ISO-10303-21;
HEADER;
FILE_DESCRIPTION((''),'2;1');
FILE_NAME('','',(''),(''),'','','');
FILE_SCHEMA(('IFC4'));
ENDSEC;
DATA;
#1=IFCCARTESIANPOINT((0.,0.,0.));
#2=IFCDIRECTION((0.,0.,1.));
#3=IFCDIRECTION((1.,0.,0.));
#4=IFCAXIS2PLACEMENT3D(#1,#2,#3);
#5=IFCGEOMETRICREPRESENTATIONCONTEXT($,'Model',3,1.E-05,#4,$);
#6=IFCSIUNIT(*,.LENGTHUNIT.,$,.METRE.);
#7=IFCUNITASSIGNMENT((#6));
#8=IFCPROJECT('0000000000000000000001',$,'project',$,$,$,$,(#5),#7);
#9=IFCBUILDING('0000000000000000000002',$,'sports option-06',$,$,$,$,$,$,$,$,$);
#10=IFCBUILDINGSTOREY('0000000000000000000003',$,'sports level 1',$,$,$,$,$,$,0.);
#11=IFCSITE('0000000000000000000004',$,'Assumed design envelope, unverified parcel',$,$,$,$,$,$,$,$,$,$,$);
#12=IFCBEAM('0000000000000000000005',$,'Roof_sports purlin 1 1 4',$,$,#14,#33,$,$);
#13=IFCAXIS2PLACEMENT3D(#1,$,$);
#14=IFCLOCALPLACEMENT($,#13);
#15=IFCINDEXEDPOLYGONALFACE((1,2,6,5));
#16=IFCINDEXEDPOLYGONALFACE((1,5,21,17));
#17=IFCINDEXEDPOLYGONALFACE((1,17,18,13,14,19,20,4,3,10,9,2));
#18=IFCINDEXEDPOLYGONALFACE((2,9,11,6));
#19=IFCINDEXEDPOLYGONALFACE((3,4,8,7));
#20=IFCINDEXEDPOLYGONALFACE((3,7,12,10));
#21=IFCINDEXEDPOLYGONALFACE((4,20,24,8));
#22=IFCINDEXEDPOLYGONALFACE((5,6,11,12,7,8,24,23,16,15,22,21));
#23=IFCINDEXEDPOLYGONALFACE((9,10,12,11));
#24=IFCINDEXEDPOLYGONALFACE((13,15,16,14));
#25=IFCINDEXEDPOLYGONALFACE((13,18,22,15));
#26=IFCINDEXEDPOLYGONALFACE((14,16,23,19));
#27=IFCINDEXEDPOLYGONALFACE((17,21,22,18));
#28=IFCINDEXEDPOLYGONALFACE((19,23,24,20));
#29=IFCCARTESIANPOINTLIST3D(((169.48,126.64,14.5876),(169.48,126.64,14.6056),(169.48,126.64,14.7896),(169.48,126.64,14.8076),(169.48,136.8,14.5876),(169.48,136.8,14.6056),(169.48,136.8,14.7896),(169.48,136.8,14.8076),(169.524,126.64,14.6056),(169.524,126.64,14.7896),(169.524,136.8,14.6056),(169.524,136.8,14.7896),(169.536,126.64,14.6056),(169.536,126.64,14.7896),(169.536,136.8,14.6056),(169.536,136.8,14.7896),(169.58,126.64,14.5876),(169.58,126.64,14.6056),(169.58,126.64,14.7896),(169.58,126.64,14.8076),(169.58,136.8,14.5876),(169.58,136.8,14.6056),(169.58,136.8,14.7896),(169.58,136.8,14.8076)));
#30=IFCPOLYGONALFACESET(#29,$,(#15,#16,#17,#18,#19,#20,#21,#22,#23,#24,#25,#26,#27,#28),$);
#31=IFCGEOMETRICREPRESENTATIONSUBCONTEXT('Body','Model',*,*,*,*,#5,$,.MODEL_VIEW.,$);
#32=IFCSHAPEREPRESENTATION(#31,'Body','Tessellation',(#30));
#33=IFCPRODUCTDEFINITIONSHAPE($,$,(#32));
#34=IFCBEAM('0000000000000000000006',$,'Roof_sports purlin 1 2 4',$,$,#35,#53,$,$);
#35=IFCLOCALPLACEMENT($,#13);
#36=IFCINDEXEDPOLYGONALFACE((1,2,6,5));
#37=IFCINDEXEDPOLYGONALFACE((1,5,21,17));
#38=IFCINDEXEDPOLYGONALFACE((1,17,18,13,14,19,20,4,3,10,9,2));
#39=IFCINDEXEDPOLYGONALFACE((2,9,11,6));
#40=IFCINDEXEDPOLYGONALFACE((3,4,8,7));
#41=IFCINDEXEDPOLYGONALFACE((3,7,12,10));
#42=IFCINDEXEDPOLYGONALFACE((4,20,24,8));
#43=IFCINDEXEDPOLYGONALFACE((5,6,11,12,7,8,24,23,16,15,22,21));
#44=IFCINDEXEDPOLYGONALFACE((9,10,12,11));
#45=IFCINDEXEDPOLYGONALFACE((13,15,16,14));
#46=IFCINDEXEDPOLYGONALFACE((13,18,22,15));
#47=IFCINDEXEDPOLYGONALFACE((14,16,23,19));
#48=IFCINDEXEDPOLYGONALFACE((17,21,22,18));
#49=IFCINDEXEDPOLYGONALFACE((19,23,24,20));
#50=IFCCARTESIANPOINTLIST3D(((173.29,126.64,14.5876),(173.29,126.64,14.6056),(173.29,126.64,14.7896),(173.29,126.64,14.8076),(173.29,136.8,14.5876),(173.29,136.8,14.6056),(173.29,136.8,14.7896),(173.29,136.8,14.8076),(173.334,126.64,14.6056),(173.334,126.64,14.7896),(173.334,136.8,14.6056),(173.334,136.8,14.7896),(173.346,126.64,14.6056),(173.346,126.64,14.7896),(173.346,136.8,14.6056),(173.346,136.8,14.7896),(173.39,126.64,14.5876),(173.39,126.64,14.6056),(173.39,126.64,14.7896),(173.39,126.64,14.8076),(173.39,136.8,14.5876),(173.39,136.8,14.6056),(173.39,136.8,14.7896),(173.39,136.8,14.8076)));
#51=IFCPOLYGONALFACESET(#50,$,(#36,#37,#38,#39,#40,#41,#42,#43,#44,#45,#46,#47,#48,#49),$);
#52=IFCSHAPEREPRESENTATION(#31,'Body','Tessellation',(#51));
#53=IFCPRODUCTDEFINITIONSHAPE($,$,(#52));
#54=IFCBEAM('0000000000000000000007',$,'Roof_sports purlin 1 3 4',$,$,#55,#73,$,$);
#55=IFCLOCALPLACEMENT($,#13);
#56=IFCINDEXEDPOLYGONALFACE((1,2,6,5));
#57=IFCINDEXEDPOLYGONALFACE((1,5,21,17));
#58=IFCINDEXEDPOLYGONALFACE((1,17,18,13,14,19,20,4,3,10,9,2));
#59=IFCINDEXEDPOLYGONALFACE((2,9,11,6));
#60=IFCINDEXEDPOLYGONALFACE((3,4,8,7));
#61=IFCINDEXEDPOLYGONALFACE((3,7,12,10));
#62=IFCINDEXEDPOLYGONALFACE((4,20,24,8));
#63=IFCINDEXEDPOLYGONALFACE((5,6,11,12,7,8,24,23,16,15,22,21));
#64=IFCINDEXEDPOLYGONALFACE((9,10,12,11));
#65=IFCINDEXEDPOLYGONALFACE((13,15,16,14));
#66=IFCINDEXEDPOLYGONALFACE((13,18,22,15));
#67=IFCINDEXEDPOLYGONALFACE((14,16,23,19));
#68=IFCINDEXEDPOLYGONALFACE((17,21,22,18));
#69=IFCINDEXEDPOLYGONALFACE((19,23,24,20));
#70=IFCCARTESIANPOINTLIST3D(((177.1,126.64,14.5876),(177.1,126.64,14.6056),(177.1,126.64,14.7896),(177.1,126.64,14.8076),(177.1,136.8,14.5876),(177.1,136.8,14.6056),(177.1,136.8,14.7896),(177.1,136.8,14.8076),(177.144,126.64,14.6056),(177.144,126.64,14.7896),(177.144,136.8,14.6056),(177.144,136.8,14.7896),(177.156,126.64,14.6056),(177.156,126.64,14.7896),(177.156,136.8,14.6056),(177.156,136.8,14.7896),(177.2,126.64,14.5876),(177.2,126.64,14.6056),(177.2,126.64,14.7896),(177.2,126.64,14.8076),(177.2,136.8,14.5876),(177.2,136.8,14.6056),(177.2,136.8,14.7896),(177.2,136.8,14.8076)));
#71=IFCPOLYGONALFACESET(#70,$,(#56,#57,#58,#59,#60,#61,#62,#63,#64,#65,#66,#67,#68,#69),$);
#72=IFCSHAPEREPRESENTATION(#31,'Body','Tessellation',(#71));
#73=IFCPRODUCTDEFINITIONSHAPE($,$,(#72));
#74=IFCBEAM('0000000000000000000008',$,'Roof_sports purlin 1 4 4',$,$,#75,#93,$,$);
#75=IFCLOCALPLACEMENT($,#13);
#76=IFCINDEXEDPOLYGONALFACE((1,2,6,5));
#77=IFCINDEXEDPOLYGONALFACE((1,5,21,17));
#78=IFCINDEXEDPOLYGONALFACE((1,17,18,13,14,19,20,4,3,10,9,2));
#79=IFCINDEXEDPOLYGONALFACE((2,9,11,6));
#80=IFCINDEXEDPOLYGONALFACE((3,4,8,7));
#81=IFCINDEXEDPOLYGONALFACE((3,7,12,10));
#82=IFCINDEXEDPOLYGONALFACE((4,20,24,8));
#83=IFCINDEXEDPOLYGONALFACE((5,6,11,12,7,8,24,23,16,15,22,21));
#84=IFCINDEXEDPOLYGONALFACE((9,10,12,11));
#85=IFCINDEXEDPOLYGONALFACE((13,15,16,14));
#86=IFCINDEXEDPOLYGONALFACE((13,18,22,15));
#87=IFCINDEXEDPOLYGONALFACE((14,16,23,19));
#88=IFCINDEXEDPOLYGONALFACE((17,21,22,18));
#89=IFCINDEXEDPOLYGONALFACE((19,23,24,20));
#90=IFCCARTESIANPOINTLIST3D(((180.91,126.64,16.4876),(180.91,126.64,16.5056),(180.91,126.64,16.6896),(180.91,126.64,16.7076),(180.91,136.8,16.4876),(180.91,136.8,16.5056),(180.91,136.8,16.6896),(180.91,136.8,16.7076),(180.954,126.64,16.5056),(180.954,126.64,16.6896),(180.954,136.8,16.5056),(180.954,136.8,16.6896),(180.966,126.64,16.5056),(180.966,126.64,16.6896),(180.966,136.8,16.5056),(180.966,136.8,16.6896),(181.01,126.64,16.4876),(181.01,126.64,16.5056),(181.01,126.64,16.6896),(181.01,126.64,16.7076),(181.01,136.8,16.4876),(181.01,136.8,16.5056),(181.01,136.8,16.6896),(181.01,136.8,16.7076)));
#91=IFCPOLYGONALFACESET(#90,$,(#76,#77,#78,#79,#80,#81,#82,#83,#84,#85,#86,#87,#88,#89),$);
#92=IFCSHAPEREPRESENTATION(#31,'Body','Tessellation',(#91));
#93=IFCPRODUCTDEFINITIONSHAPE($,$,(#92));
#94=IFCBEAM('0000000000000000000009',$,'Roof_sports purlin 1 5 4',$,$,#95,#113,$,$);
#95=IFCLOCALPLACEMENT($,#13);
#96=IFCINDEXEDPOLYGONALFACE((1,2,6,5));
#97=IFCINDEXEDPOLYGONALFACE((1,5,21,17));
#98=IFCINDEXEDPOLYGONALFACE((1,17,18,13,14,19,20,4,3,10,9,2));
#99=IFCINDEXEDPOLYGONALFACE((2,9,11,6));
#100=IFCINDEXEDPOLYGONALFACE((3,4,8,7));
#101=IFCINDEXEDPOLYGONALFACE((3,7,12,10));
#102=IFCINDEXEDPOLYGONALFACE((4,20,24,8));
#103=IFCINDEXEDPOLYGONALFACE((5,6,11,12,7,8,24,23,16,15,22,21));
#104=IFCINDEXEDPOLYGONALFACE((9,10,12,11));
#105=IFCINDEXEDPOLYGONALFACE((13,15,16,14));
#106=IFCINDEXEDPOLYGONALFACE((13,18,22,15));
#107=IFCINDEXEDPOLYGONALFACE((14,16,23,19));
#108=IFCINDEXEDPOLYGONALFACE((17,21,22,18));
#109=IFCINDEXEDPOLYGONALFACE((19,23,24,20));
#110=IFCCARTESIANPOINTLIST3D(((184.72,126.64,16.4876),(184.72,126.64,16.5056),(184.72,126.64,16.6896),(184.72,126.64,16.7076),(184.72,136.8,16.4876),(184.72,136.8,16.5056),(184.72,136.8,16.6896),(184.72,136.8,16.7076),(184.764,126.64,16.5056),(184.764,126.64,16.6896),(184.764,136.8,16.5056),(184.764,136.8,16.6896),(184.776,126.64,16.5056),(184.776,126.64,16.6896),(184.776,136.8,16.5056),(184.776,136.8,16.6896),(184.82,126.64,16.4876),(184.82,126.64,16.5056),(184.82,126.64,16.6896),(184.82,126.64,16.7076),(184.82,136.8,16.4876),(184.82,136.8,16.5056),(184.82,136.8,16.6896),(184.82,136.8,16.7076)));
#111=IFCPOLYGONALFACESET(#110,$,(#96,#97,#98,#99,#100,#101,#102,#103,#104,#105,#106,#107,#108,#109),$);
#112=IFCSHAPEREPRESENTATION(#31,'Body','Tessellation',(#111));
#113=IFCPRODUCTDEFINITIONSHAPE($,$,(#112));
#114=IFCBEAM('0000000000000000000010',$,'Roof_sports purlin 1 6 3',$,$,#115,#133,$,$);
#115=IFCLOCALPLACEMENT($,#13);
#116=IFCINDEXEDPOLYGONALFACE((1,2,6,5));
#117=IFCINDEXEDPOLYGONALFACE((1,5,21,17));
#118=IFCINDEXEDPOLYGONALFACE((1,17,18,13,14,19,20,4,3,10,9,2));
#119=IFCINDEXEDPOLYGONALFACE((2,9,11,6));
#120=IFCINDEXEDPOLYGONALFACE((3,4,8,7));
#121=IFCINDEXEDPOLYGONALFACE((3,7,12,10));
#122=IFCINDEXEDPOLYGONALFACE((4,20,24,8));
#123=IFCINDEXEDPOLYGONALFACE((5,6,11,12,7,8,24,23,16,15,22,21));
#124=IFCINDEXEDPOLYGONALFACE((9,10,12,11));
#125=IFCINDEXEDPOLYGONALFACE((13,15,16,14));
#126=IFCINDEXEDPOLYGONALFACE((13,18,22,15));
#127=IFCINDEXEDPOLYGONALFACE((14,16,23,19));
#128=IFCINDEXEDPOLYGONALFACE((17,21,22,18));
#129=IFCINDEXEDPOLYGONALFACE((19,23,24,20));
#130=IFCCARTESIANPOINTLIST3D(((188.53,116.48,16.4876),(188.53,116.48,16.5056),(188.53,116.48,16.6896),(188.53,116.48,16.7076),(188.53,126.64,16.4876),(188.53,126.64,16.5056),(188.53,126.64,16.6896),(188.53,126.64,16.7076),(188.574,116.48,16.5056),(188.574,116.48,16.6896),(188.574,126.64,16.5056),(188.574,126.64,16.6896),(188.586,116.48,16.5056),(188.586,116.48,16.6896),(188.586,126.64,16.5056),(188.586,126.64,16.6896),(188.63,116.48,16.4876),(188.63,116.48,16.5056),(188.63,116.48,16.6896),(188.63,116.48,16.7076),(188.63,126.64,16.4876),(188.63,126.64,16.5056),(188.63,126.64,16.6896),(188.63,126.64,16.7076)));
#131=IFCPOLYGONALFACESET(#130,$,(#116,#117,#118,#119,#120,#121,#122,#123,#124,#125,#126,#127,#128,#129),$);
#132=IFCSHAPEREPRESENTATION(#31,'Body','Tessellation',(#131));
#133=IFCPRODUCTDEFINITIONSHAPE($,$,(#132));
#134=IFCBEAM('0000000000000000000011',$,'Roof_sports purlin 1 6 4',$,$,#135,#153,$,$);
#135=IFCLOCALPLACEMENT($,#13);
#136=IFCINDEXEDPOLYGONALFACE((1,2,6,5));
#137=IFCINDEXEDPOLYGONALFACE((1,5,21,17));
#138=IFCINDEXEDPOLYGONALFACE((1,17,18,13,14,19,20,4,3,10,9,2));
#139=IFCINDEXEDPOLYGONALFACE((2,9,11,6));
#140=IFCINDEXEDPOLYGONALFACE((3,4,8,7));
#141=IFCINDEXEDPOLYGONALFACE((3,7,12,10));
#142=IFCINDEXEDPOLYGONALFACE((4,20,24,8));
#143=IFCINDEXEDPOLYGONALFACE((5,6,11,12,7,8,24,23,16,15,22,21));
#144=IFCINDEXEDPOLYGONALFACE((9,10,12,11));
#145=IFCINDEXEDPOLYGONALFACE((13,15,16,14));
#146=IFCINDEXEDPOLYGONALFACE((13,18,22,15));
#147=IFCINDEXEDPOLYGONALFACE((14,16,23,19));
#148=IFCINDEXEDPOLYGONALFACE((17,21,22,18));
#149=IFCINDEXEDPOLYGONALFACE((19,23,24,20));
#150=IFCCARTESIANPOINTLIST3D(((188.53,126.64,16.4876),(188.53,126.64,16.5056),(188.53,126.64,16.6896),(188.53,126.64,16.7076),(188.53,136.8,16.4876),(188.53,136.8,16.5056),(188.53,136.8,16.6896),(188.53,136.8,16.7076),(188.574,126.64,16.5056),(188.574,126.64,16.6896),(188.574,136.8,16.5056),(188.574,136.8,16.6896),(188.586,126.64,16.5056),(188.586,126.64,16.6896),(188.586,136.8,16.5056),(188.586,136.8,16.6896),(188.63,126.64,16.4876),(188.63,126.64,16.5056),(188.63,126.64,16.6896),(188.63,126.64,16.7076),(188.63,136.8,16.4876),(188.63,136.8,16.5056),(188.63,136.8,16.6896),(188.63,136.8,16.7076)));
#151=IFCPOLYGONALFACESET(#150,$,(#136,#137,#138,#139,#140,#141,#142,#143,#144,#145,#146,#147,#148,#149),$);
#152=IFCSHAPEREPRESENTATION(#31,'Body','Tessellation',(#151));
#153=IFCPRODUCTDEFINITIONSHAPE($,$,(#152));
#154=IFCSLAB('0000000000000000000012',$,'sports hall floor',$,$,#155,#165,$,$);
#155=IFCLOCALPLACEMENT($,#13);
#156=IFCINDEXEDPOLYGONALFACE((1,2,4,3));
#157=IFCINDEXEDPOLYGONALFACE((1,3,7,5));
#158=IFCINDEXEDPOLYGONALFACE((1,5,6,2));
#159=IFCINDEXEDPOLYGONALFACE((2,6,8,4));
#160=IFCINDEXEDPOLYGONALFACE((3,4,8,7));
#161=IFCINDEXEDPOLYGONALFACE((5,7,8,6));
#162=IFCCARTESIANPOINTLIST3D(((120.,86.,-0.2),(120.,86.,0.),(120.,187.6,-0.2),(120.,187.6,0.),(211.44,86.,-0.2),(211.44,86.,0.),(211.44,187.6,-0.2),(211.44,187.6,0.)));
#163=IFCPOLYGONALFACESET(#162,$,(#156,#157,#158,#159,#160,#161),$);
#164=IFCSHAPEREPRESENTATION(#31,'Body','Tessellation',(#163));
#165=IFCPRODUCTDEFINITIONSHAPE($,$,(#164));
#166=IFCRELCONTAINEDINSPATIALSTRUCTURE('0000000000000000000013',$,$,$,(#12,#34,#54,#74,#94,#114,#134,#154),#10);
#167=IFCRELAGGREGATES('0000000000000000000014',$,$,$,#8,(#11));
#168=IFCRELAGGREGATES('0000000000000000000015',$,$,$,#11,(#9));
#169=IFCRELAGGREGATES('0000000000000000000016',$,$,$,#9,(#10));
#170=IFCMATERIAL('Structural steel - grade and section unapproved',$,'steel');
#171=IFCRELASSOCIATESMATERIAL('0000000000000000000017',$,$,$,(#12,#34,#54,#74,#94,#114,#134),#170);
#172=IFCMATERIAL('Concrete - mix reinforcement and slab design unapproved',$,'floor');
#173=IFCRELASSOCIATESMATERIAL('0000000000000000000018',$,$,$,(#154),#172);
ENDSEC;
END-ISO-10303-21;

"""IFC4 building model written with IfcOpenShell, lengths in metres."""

from ifc_helpers import new_model, si_unit, frame, origin_with_axes, place, context, subcontext, project, spatial, rectangle, i_section, extrude, material, element, save


model = new_model("IFC4")

# Units and contexts
model_context = context("Model", 3, precision=1e-05, world=origin_with_axes())
body_context = subcontext(model_context, "Body", "Model", "MODEL_VIEW")
ifc_project = project(units=[si_unit("LENGTHUNIT", "METRE")], contexts=[model_context])

# Site, building, storey
site = spatial("IfcSite", under=ifc_project, Name="Assumed design envelope, unverified parcel")
building = spatial("IfcBuilding", under=site, Name="sports option-06")
storey = spatial("IfcBuildingStorey", under=building, Name="sports level 1", Elevation=0.0)

# Shared definitions
ifc_material_1 = material(Name="Structural steel - grade and section unapproved", Category="steel")

# Beams
for number, where, z_axis, x_axis, name in (
    (1, (169.53, 126.64, 14.6976), (0.0, 1.0, 0.0), (-1.0, 0.0, 0.0), "Roof_sports purlin 1 1 4"),
    (2, (173.34, 126.64, 14.6976), (0.0, 1.0, 0.0), (-1.0, 0.0, 0.0), "Roof_sports purlin 1 2 4"),
    (3, (177.15, 126.64, 14.6976), (0.0, 1.0, 0.0), (-1.0, 0.0, 0.0), "Roof_sports purlin 1 3 4"),
    (4, (180.96, 126.64, 16.5976), (0.0, 1.0, 0.0), (-1.0, 0.0, 0.0), "Roof_sports purlin 1 4 4"),
    (5, (184.77, 126.64, 16.5976), (0.0, 1.0, 0.0), (-1.0, 0.0, 0.0), "Roof_sports purlin 1 5 4"),
):
    element("IfcBeam", number, at=place(None, frame(where, z_axis=z_axis, x_axis=x_axis)), inside=storey, material=ifc_material_1, Name=name, context=body_context, shape_type="SweptSolid", body=[
        extrude(i_section(OverallWidth=0.1, OverallDepth=0.22, WebThickness=0.012, FlangeThickness=0.018, FilletRadius=0.0), origin_with_axes(), (0.0, 0.0, 1.0), 10.16),
    ])
beam_1_placement = place(None, frame((188.58, 116.48, 16.5976), z_axis=(0.0, 1.0, 0.0), x_axis=(-1.0, 0.0, 0.0)))
element("IfcBeam", 6, at=beam_1_placement, inside=storey, material=ifc_material_1, Name="Roof_sports purlin 1 6 3", context=body_context, shape_type="SweptSolid", body=[
    extrude(i_section(OverallWidth=0.1, OverallDepth=0.22, WebThickness=0.012, FlangeThickness=0.018, FilletRadius=0.0), origin_with_axes(), (0.0, 0.0, 1.0), 10.16),
])
beam_2_placement = place(None, frame((188.58, 126.64, 16.5976), z_axis=(0.0, 1.0, 0.0), x_axis=(-1.0, 0.0, 0.0)))
element("IfcBeam", 7, at=beam_2_placement, inside=storey, material=ifc_material_1, Name="Roof_sports purlin 1 6 4", context=body_context, shape_type="SweptSolid", body=[
    extrude(i_section(OverallWidth=0.1, OverallDepth=0.22, WebThickness=0.012, FlangeThickness=0.018, FilletRadius=0.0), origin_with_axes(), (0.0, 0.0, 1.0), 10.16),
])

# Slab
ifc_material_2 = material(Name="Concrete - mix reinforcement and slab design unapproved", Category="floor")
slab_placement = place(None, frame((165.72, 136.8, -0.2), z_axis=(0.0, 0.0, 1.0), x_axis=(1.0, 0.0, 0.0)))
element("IfcSlab", 8, at=slab_placement, inside=storey, material=ifc_material_2, Name="sports hall floor", context=body_context, shape_type="SweptSolid", body=[
    extrude(rectangle(XDim=91.44, YDim=101.6), origin_with_axes(), (0.0, 0.0, 1.0), 0.2),
])

save(model, "model.ifc")
